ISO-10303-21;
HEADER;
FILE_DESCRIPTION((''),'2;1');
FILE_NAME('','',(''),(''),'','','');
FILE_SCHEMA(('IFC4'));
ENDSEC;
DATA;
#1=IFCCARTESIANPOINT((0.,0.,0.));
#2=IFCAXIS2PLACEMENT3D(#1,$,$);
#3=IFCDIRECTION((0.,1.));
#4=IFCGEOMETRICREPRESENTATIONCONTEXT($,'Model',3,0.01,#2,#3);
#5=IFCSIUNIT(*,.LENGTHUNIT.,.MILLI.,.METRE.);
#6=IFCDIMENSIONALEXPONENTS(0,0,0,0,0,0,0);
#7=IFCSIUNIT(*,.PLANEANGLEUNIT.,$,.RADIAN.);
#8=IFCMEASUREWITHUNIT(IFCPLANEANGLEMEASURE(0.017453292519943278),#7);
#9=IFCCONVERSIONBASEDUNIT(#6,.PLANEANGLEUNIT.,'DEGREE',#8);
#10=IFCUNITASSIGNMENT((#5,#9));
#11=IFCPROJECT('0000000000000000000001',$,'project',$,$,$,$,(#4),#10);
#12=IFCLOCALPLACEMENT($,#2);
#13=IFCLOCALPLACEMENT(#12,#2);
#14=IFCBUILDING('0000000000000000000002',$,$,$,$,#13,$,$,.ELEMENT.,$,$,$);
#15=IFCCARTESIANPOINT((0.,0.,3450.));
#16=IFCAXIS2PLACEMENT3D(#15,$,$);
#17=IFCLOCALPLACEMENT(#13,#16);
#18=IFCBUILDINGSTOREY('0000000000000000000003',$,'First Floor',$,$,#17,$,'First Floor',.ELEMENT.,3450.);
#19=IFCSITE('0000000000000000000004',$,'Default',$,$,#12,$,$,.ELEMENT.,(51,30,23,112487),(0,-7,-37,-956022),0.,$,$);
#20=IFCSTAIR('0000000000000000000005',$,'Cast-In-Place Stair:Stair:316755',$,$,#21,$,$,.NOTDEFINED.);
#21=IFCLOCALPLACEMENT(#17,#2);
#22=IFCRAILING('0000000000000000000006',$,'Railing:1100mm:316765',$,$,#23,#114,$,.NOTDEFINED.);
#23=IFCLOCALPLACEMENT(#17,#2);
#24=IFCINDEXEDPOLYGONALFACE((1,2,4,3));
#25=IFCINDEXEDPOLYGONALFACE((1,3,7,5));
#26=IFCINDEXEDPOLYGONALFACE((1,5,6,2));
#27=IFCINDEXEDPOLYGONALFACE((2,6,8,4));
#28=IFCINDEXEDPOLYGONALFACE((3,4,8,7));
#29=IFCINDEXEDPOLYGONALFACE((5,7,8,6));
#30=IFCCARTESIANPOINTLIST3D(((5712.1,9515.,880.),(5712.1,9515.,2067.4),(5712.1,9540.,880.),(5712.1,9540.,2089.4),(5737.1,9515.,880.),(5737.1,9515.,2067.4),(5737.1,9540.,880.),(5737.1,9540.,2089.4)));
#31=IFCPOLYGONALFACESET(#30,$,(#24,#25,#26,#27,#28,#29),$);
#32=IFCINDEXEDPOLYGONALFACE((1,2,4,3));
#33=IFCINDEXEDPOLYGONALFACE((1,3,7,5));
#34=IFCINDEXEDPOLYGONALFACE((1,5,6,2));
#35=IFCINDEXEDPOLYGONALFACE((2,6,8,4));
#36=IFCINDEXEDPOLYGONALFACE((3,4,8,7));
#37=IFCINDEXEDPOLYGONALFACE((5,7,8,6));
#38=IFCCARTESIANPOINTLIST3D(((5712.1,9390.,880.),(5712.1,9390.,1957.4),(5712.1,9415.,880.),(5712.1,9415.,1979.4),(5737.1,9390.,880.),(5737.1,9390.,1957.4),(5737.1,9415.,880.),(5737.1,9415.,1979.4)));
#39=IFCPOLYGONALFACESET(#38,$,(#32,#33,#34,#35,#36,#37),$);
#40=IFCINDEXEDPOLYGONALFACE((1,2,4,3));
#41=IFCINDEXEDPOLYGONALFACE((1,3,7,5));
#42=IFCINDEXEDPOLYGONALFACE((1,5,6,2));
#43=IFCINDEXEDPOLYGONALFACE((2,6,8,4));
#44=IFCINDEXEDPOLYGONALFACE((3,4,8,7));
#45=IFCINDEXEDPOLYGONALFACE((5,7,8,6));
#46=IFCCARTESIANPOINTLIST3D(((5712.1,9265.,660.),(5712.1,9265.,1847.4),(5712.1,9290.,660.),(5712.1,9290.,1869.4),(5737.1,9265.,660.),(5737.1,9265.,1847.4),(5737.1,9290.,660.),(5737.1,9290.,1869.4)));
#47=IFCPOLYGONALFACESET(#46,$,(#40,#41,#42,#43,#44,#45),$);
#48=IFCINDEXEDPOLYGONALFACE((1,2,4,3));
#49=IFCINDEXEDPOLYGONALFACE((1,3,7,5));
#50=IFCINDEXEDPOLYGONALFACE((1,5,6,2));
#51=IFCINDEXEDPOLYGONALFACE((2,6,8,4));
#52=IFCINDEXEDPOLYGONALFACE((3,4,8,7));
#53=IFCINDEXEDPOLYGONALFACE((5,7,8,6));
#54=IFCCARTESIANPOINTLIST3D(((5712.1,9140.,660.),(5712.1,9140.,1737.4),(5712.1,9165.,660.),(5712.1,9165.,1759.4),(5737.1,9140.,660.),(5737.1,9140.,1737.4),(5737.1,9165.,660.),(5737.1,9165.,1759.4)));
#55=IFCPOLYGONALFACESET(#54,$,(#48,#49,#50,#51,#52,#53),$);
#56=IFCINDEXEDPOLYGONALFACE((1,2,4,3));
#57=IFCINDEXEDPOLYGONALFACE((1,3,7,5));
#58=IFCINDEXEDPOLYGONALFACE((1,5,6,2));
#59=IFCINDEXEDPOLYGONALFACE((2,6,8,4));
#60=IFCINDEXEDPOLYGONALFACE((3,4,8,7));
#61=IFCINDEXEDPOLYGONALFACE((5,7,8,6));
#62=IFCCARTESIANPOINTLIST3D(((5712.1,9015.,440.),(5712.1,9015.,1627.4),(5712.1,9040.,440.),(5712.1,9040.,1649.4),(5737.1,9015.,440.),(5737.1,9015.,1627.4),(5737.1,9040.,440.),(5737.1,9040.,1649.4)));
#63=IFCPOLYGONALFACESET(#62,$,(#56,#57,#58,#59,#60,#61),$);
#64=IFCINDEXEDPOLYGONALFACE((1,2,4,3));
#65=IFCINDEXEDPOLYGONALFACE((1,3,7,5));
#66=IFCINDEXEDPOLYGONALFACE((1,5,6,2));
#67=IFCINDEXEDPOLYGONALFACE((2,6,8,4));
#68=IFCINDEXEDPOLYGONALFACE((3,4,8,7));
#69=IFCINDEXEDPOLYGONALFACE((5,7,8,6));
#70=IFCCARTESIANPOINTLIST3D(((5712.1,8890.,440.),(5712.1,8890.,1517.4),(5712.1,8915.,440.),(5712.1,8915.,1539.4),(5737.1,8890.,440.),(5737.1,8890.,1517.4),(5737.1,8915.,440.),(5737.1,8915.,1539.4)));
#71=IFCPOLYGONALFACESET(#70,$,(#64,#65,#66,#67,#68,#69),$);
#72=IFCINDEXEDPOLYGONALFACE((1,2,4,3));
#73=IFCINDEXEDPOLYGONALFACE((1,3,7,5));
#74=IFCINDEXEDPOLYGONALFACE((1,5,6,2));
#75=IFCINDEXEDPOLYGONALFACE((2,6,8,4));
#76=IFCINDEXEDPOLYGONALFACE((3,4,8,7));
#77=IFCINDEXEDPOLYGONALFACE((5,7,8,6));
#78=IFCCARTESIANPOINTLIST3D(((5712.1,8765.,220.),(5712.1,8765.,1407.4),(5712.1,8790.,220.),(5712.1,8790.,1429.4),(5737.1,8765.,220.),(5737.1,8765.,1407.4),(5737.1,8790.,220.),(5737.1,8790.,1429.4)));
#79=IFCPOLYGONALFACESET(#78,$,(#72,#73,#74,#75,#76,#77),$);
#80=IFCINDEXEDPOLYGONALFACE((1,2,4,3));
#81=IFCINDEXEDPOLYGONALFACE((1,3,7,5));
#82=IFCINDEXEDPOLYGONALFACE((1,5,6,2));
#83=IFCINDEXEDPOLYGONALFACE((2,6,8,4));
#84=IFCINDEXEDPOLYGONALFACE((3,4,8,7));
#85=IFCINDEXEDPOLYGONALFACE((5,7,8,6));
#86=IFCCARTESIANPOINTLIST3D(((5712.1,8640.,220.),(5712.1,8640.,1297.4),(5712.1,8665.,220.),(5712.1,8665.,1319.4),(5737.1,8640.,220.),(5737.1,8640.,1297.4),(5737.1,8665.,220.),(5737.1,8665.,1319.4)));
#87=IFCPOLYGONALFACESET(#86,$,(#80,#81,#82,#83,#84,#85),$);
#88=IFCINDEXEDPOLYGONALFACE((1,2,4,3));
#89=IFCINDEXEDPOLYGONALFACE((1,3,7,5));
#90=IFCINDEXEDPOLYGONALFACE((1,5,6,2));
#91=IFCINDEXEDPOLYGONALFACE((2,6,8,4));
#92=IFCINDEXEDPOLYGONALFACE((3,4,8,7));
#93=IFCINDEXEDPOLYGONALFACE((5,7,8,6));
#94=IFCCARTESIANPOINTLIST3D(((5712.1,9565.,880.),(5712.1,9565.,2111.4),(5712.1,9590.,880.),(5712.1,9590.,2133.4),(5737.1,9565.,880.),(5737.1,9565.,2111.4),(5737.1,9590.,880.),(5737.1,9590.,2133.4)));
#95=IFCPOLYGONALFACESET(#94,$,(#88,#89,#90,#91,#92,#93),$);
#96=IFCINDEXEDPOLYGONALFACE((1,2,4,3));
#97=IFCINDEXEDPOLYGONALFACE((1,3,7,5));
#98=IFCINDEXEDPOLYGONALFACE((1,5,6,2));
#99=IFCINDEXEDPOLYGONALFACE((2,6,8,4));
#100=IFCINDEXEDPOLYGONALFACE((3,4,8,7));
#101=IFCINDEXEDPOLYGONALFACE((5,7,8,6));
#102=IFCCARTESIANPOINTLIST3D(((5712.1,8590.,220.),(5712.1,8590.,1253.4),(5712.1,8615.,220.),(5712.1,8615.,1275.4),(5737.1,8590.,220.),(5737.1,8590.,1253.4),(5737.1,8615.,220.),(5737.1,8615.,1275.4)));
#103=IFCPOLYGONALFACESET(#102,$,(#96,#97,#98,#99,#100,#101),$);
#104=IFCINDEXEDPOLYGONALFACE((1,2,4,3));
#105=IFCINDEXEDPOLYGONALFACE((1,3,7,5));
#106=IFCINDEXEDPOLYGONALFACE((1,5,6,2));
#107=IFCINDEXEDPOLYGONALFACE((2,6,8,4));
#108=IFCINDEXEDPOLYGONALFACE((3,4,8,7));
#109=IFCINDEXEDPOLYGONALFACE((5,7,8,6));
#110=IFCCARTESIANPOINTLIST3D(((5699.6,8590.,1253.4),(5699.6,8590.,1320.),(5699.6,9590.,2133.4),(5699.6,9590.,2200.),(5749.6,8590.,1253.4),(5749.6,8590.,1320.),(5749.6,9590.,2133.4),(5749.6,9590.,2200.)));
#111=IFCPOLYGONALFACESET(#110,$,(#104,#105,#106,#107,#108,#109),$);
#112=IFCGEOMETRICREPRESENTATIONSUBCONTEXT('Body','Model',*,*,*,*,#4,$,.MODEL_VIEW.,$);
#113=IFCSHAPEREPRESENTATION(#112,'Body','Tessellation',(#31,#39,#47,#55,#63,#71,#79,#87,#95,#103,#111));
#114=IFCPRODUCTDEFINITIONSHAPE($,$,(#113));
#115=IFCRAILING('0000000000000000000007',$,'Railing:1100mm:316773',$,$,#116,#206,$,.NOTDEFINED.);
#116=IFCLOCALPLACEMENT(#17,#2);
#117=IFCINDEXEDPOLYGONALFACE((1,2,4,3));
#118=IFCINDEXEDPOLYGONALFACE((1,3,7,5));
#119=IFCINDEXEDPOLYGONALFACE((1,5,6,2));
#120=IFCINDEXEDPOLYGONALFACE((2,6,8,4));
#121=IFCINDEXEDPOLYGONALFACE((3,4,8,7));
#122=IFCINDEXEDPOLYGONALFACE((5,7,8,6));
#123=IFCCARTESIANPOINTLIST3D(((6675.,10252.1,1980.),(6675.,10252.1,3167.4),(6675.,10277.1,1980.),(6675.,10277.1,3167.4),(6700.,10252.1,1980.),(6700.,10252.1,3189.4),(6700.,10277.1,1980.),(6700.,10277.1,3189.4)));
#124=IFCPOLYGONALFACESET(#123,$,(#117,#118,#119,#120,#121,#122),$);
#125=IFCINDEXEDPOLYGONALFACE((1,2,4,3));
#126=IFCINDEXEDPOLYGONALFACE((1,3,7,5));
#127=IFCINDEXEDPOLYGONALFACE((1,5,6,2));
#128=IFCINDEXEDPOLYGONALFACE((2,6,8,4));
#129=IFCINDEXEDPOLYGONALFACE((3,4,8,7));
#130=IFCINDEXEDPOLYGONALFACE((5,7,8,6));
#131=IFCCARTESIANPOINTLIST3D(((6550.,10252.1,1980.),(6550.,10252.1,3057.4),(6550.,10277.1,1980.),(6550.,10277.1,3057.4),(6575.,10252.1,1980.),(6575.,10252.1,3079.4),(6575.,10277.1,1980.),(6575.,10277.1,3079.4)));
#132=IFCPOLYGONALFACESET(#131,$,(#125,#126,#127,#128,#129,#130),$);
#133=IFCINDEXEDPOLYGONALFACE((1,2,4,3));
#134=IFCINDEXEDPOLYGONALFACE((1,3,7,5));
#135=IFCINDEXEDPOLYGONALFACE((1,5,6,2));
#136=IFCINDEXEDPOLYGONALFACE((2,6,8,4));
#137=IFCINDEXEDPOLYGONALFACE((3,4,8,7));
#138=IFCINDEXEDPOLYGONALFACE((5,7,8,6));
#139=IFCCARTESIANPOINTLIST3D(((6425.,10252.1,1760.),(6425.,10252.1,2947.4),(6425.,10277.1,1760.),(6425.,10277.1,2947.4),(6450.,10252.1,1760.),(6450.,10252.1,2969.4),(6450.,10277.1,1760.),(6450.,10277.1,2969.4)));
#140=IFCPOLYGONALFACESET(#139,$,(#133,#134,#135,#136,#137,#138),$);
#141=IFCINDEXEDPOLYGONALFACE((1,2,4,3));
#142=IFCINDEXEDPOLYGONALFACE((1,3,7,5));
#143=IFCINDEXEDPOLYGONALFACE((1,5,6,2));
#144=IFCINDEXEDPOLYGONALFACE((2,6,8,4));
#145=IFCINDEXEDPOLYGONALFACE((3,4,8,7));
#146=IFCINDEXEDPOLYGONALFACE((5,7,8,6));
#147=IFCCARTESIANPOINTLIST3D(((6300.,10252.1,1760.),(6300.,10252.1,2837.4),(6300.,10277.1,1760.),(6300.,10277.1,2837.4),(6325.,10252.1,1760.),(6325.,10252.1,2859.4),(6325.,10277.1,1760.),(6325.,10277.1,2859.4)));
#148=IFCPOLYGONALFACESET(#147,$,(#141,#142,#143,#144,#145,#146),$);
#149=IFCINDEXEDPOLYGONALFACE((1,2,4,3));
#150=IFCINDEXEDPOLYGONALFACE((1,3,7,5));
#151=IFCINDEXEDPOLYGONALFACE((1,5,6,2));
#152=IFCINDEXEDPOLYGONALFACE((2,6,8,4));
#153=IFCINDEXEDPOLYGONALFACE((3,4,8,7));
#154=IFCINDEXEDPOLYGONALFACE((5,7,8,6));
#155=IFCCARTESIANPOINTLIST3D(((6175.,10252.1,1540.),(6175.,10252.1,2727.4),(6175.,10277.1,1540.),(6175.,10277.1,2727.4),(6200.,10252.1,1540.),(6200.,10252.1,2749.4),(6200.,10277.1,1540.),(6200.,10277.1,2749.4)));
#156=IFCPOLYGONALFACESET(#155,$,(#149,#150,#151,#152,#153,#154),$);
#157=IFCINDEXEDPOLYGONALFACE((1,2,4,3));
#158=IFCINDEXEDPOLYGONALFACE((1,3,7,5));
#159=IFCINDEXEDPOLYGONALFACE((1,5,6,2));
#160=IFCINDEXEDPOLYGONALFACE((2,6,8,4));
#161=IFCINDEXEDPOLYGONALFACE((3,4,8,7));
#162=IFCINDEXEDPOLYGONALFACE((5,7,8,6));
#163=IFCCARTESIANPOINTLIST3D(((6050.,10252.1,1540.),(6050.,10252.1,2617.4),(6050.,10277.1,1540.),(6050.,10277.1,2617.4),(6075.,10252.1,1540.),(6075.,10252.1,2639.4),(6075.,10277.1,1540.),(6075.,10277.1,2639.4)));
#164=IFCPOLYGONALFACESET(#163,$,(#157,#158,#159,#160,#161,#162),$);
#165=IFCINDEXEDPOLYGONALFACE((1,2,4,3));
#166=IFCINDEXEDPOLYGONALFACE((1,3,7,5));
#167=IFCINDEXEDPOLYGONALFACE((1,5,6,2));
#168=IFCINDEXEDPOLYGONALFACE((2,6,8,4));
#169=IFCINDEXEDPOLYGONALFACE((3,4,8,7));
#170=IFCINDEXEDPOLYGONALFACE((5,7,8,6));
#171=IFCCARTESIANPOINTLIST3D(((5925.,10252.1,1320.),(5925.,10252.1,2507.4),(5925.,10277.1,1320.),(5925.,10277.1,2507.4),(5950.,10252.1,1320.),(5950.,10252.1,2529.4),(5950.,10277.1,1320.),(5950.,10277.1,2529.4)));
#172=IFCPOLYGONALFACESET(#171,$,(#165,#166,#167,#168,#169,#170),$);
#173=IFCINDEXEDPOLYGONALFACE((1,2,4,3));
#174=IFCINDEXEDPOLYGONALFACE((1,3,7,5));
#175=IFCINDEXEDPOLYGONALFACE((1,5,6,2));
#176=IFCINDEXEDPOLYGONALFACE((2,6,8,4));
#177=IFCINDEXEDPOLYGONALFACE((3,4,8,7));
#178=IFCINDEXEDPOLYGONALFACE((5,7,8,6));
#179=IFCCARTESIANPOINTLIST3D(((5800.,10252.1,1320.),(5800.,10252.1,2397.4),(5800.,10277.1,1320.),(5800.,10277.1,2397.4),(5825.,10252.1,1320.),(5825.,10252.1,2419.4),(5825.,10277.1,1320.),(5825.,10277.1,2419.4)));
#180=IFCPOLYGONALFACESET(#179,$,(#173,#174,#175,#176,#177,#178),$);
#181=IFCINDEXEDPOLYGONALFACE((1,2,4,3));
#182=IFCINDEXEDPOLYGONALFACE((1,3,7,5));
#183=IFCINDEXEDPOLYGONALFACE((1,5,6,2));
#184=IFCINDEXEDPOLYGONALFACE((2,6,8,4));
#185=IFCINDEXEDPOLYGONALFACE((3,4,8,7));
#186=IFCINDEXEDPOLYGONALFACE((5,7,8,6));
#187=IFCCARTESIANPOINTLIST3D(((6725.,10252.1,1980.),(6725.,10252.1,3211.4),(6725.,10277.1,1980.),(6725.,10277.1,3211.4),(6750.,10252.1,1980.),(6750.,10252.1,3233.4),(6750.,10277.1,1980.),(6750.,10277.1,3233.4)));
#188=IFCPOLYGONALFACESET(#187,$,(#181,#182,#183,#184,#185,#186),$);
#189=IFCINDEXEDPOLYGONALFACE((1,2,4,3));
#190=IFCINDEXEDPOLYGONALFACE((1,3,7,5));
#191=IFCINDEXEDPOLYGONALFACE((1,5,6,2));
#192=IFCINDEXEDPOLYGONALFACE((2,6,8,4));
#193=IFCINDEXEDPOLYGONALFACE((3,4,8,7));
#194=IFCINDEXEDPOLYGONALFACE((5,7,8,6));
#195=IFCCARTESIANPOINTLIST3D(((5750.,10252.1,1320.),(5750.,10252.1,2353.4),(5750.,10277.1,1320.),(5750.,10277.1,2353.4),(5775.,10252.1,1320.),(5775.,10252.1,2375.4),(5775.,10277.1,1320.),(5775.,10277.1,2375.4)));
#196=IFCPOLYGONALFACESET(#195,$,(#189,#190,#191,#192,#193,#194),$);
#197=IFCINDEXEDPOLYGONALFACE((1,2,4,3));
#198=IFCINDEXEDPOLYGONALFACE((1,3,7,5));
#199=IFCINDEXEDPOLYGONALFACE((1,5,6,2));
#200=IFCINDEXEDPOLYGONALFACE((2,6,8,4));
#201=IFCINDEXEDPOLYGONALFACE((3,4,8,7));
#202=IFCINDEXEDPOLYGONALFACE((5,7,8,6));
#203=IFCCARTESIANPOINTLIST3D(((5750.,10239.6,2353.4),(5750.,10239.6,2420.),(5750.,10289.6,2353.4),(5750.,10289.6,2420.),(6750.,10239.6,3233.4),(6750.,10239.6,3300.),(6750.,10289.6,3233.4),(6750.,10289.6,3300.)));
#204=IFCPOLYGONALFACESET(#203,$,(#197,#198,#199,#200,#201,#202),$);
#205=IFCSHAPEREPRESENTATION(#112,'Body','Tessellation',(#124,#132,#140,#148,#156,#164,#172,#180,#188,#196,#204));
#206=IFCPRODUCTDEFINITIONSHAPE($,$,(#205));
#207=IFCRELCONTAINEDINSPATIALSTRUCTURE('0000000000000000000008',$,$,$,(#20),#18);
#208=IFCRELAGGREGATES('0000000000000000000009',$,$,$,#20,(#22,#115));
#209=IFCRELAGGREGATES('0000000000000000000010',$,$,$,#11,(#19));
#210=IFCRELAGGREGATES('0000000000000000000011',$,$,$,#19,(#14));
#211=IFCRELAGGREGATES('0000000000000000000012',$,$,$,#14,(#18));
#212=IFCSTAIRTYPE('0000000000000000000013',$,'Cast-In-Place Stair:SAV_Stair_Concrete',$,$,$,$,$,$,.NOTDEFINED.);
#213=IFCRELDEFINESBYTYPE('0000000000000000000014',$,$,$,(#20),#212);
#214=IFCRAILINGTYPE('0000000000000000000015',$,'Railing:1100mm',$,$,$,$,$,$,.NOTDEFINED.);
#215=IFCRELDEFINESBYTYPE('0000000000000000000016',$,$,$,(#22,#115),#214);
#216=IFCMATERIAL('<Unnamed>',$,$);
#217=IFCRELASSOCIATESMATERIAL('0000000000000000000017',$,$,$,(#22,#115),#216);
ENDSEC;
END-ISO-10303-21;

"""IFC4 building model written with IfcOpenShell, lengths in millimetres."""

from ifc_helpers import new_model, entity, si_unit, converted_unit, direction, frame, origin, place, context, subcontext, project, spatial, polyline, outline, extrude, material, type_object, element, aggregate, save


model = new_model("IFC4")

# Units and contexts
model_context = context("Model", 3, precision=0.01, world=origin(), true_north=direction((0.0, 1.0)))
body_context = subcontext(model_context, "Body", "Model", "MODEL_VIEW")
ifc_project = project(units=[si_unit("LENGTHUNIT", "METRE", prefix="MILLI"), converted_unit("PLANEANGLEUNIT", "DEGREE", entity("IfcPlaneAngleMeasure", 0.017453292519943278), si_unit("PLANEANGLEUNIT", "RADIAN"), dimensions=[0, 0, 0, 0, 0, 0, 0])], contexts=[model_context])

# Site, building, storey
site_placement = place(None, origin())
site = spatial("IfcSite", under=ifc_project, at=site_placement, Name="Default", CompositionType="ELEMENT", RefLatitude=(51, 30, 23, 112487), RefLongitude=(0, -7, -37, -956022), RefElevation=0.0)
building_placement = place(site_placement, origin())
building = spatial("IfcBuilding", under=site, at=building_placement, CompositionType="ELEMENT")
storey_placement = place(building_placement, frame((0.0, 0.0, 3450.0)))
storey = spatial("IfcBuildingStorey", under=building, at=storey_placement, Name="First Floor", LongName="First Floor", CompositionType="ELEMENT", Elevation=3450.0)

# Shared definitions
ifc_material_1 = material(Name="<Unnamed>")

# Stair, railings
stair_type = type_object("IfcStairType", Name="Cast-In-Place Stair:SAV_Stair_Concrete", PredefinedType="NOTDEFINED")
stair_placement = place(storey_placement, origin())
stair = element("IfcStair", 1, at=stair_placement, inside=storey, type_object=stair_type, Name="Cast-In-Place Stair:Stair:316755", PredefinedType="NOTDEFINED")
railing_type_1 = type_object("IfcRailingType", Name="Railing:1100mm", PredefinedType="NOTDEFINED")
railing_1_placement = place(stair_placement, frame((5699.6, 8590.0, 220.0)))
railing_1 = element("IfcRailing", 2, at=railing_1_placement, type_object=railing_type_1, material=ifc_material_1, Name="Railing:1100mm:316765", PredefinedType="NOTDEFINED", context=body_context, shape_type="SweptSolid", body=[
    extrude(outline(polyline([(-12.5, -599.2), (12.5, -599.2), (12.5, 610.2), (-12.5, 588.2), (-12.5, -599.2)])), frame((12.5, 937.5, 1259.2), z_axis=(1.0, 0.0, 0.0), x_axis=(0.0, 1.0, 0.0)), (0.0, 0.0, 1.0), 25.0),
    extrude(outline(polyline([(-12.5, -544.2), (12.5, -544.2), (12.5, 555.2), (-12.5, 533.2), (-12.5, -544.2)])), frame((12.5, 812.5, 1204.2), z_axis=(1.0, 0.0, 0.0), x_axis=(0.0, 1.0, 0.0)), (0.0, 0.0, 1.0), 25.0),
    extrude(outline(polyline([(-12.5, -599.2), (12.5, -599.2), (12.5, 610.2), (-12.5, 588.2), (-12.5, -599.2)])), frame((12.5, 687.5, 1039.2), z_axis=(1.0, 0.0, 0.0), x_axis=(0.0, 1.0, 0.0)), (0.0, 0.0, 1.0), 25.0),
    extrude(outline(polyline([(-12.5, -544.2), (12.5, -544.2), (12.5, 555.2), (-12.5, 533.2), (-12.5, -544.2)])), frame((12.5, 562.5, 984.2), z_axis=(1.0, 0.0, 0.0), x_axis=(0.0, 1.0, 0.0)), (0.0, 0.0, 1.0), 25.0),
    extrude(outline(polyline([(-12.5, -599.2), (12.5, -599.2), (12.5, 610.2), (-12.5, 588.2), (-12.5, -599.2)])), frame((12.5, 437.5, 819.2), z_axis=(1.0, 0.0, 0.0), x_axis=(0.0, 1.0, 0.0)), (0.0, 0.0, 1.0), 25.0),
    extrude(outline(polyline([(-12.5, -544.2), (12.5, -544.2), (12.5, 555.2), (-12.5, 533.2), (-12.5, -544.2)])), frame((12.5, 312.5, 764.2), z_axis=(1.0, 0.0, 0.0), x_axis=(0.0, 1.0, 0.0)), (0.0, 0.0, 1.0), 25.0),
    extrude(outline(polyline([(-12.5, -599.2), (12.5, -599.2), (12.5, 610.2), (-12.5, 588.2), (-12.5, -599.2)])), frame((12.5, 187.5, 599.2), z_axis=(1.0, 0.0, 0.0), x_axis=(0.0, 1.0, 0.0)), (0.0, 0.0, 1.0), 25.0),
    extrude(outline(polyline([(-12.5, -544.2), (12.5, -544.2), (12.5, 555.2), (-12.5, 533.2), (-12.5, -544.2)])), frame((12.5, 62.5, 544.2), z_axis=(1.0, 0.0, 0.0), x_axis=(0.0, 1.0, 0.0)), (0.0, 0.0, 1.0), 25.0),
    extrude(outline(polyline([(-12.5, -621.2), (12.5, -621.2), (12.5, 632.2), (-12.5, 610.2), (-12.5, -621.2)])), frame((12.5, 987.5, 1281.2), z_axis=(1.0, 0.0, 0.0), x_axis=(0.0, 1.0, 0.0)), (0.0, 0.0, 1.0), 25.0),
    extrude(outline(polyline([(-12.5, -522.2), (12.5, -522.2), (12.5, 533.2), (-12.5, 511.2), (-12.5, -522.2)])), frame((12.5, 12.5, 522.2), z_axis=(1.0, 0.0, 0.0), x_axis=(0.0, 1.0, 0.0)), (0.0, 0.0, 1.0), 25.0),
    extrude(outline(polyline([(-688.0, -25.0), (644.0, -25.0), (688.0, 25.0), (-644.0, 25.0), (-688.0, -25.0)])), frame((0.0, 500.0, 1506.7), z_axis=(1.0, 0.0, 0.0), x_axis=(0.0, 0.750714, 0.660628)), (0.0, 0.0, 1.0), 50.0),
])
railing_2_placement = place(stair_placement, frame((5750.0, 10239.6, 1320.0)))
railing_2 = element("IfcRailing", 3, at=railing_2_placement, type_object=railing_type_1, material=ifc_material_1, Name="Railing:1100mm:316773", PredefinedType="NOTDEFINED", context=body_context, shape_type="SweptSolid", body=[
    extrude(outline(polyline([(-599.2, -12.5), (588.2, -12.5), (610.2, 12.5), (-599.2, 12.5), (-599.2, -12.5)])), frame((937.5, 12.5, 1259.2), z_axis=(0.0, 1.0, 0.0), x_axis=(0.0, 0.0, 1.0)), (0.0, 0.0, 1.0), 25.0),
    extrude(outline(polyline([(-544.2, -12.5), (533.2, -12.5), (555.2, 12.5), (-544.2, 12.5), (-544.2, -12.5)])), frame((812.5, 12.5, 1204.2), z_axis=(0.0, 1.0, 0.0), x_axis=(0.0, 0.0, 1.0)), (0.0, 0.0, 1.0), 25.0),
    extrude(outline(polyline([(-599.2, -12.5), (588.2, -12.5), (610.2, 12.5), (-599.2, 12.5), (-599.2, -12.5)])), frame((687.5, 12.5, 1039.2), z_axis=(0.0, 1.0, 0.0), x_axis=(0.0, 0.0, 1.0)), (0.0, 0.0, 1.0), 25.0),
    extrude(outline(polyline([(-544.2, -12.5), (533.2, -12.5), (555.2, 12.5), (-544.2, 12.5), (-544.2, -12.5)])), frame((562.5, 12.5, 984.2), z_axis=(0.0, 1.0, 0.0), x_axis=(0.0, 0.0, 1.0)), (0.0, 0.0, 1.0), 25.0),
    extrude(outline(polyline([(-599.2, -12.5), (588.2, -12.5), (610.2, 12.5), (-599.2, 12.5), (-599.2, -12.5)])), frame((437.5, 12.5, 819.2), z_axis=(0.0, 1.0, 0.0), x_axis=(0.0, 0.0, 1.0)), (0.0, 0.0, 1.0), 25.0),
    extrude(outline(polyline([(-544.2, -12.5), (533.2, -12.5), (555.2, 12.5), (-544.2, 12.5), (-544.2, -12.5)])), frame((312.5, 12.5, 764.2), z_axis=(0.0, 1.0, 0.0), x_axis=(0.0, 0.0, 1.0)), (0.0, 0.0, 1.0), 25.0),
    extrude(outline(polyline([(-599.2, -12.5), (588.2, -12.5), (610.2, 12.5), (-599.2, 12.5), (-599.2, -12.5)])), frame((187.5, 12.5, 599.2), z_axis=(0.0, 1.0, 0.0), x_axis=(0.0, 0.0, 1.0)), (0.0, 0.0, 1.0), 25.0),
    extrude(outline(polyline([(-544.2, -12.5), (533.2, -12.5), (555.2, 12.5), (-544.2, 12.5), (-544.2, -12.5)])), frame((62.5, 12.5, 544.2), z_axis=(0.0, 1.0, 0.0), x_axis=(0.0, 0.0, 1.0)), (0.0, 0.0, 1.0), 25.0),
    extrude(outline(polyline([(-621.2, -12.5), (610.2, -12.5), (632.2, 12.5), (-621.2, 12.5), (-621.2, -12.5)])), frame((987.5, 12.5, 1281.2), z_axis=(0.0, 1.0, 0.0), x_axis=(0.0, 0.0, 1.0)), (0.0, 0.0, 1.0), 25.0),
    extrude(outline(polyline([(-522.2, -12.5), (511.2, -12.5), (533.2, 12.5), (-522.2, 12.5), (-522.2, -12.5)])), frame((12.5, 12.5, 522.2), z_axis=(0.0, 1.0, 0.0), x_axis=(0.0, 0.0, 1.0)), (0.0, 0.0, 1.0), 25.0),
    extrude(outline(polyline([(-644.0, -25.0), (688.0, -25.0), (644.0, 25.0), (-688.0, 25.0), (-644.0, -25.0)])), frame((500.0, 0.0, 1506.7), z_axis=(0.0, 1.0, 0.0), x_axis=(0.750714, 0.0, 0.660628)), (0.0, 0.0, 1.0), 50.0),
])
aggregate(stair, [railing_1, railing_2])

save(model, "model.ifc")
